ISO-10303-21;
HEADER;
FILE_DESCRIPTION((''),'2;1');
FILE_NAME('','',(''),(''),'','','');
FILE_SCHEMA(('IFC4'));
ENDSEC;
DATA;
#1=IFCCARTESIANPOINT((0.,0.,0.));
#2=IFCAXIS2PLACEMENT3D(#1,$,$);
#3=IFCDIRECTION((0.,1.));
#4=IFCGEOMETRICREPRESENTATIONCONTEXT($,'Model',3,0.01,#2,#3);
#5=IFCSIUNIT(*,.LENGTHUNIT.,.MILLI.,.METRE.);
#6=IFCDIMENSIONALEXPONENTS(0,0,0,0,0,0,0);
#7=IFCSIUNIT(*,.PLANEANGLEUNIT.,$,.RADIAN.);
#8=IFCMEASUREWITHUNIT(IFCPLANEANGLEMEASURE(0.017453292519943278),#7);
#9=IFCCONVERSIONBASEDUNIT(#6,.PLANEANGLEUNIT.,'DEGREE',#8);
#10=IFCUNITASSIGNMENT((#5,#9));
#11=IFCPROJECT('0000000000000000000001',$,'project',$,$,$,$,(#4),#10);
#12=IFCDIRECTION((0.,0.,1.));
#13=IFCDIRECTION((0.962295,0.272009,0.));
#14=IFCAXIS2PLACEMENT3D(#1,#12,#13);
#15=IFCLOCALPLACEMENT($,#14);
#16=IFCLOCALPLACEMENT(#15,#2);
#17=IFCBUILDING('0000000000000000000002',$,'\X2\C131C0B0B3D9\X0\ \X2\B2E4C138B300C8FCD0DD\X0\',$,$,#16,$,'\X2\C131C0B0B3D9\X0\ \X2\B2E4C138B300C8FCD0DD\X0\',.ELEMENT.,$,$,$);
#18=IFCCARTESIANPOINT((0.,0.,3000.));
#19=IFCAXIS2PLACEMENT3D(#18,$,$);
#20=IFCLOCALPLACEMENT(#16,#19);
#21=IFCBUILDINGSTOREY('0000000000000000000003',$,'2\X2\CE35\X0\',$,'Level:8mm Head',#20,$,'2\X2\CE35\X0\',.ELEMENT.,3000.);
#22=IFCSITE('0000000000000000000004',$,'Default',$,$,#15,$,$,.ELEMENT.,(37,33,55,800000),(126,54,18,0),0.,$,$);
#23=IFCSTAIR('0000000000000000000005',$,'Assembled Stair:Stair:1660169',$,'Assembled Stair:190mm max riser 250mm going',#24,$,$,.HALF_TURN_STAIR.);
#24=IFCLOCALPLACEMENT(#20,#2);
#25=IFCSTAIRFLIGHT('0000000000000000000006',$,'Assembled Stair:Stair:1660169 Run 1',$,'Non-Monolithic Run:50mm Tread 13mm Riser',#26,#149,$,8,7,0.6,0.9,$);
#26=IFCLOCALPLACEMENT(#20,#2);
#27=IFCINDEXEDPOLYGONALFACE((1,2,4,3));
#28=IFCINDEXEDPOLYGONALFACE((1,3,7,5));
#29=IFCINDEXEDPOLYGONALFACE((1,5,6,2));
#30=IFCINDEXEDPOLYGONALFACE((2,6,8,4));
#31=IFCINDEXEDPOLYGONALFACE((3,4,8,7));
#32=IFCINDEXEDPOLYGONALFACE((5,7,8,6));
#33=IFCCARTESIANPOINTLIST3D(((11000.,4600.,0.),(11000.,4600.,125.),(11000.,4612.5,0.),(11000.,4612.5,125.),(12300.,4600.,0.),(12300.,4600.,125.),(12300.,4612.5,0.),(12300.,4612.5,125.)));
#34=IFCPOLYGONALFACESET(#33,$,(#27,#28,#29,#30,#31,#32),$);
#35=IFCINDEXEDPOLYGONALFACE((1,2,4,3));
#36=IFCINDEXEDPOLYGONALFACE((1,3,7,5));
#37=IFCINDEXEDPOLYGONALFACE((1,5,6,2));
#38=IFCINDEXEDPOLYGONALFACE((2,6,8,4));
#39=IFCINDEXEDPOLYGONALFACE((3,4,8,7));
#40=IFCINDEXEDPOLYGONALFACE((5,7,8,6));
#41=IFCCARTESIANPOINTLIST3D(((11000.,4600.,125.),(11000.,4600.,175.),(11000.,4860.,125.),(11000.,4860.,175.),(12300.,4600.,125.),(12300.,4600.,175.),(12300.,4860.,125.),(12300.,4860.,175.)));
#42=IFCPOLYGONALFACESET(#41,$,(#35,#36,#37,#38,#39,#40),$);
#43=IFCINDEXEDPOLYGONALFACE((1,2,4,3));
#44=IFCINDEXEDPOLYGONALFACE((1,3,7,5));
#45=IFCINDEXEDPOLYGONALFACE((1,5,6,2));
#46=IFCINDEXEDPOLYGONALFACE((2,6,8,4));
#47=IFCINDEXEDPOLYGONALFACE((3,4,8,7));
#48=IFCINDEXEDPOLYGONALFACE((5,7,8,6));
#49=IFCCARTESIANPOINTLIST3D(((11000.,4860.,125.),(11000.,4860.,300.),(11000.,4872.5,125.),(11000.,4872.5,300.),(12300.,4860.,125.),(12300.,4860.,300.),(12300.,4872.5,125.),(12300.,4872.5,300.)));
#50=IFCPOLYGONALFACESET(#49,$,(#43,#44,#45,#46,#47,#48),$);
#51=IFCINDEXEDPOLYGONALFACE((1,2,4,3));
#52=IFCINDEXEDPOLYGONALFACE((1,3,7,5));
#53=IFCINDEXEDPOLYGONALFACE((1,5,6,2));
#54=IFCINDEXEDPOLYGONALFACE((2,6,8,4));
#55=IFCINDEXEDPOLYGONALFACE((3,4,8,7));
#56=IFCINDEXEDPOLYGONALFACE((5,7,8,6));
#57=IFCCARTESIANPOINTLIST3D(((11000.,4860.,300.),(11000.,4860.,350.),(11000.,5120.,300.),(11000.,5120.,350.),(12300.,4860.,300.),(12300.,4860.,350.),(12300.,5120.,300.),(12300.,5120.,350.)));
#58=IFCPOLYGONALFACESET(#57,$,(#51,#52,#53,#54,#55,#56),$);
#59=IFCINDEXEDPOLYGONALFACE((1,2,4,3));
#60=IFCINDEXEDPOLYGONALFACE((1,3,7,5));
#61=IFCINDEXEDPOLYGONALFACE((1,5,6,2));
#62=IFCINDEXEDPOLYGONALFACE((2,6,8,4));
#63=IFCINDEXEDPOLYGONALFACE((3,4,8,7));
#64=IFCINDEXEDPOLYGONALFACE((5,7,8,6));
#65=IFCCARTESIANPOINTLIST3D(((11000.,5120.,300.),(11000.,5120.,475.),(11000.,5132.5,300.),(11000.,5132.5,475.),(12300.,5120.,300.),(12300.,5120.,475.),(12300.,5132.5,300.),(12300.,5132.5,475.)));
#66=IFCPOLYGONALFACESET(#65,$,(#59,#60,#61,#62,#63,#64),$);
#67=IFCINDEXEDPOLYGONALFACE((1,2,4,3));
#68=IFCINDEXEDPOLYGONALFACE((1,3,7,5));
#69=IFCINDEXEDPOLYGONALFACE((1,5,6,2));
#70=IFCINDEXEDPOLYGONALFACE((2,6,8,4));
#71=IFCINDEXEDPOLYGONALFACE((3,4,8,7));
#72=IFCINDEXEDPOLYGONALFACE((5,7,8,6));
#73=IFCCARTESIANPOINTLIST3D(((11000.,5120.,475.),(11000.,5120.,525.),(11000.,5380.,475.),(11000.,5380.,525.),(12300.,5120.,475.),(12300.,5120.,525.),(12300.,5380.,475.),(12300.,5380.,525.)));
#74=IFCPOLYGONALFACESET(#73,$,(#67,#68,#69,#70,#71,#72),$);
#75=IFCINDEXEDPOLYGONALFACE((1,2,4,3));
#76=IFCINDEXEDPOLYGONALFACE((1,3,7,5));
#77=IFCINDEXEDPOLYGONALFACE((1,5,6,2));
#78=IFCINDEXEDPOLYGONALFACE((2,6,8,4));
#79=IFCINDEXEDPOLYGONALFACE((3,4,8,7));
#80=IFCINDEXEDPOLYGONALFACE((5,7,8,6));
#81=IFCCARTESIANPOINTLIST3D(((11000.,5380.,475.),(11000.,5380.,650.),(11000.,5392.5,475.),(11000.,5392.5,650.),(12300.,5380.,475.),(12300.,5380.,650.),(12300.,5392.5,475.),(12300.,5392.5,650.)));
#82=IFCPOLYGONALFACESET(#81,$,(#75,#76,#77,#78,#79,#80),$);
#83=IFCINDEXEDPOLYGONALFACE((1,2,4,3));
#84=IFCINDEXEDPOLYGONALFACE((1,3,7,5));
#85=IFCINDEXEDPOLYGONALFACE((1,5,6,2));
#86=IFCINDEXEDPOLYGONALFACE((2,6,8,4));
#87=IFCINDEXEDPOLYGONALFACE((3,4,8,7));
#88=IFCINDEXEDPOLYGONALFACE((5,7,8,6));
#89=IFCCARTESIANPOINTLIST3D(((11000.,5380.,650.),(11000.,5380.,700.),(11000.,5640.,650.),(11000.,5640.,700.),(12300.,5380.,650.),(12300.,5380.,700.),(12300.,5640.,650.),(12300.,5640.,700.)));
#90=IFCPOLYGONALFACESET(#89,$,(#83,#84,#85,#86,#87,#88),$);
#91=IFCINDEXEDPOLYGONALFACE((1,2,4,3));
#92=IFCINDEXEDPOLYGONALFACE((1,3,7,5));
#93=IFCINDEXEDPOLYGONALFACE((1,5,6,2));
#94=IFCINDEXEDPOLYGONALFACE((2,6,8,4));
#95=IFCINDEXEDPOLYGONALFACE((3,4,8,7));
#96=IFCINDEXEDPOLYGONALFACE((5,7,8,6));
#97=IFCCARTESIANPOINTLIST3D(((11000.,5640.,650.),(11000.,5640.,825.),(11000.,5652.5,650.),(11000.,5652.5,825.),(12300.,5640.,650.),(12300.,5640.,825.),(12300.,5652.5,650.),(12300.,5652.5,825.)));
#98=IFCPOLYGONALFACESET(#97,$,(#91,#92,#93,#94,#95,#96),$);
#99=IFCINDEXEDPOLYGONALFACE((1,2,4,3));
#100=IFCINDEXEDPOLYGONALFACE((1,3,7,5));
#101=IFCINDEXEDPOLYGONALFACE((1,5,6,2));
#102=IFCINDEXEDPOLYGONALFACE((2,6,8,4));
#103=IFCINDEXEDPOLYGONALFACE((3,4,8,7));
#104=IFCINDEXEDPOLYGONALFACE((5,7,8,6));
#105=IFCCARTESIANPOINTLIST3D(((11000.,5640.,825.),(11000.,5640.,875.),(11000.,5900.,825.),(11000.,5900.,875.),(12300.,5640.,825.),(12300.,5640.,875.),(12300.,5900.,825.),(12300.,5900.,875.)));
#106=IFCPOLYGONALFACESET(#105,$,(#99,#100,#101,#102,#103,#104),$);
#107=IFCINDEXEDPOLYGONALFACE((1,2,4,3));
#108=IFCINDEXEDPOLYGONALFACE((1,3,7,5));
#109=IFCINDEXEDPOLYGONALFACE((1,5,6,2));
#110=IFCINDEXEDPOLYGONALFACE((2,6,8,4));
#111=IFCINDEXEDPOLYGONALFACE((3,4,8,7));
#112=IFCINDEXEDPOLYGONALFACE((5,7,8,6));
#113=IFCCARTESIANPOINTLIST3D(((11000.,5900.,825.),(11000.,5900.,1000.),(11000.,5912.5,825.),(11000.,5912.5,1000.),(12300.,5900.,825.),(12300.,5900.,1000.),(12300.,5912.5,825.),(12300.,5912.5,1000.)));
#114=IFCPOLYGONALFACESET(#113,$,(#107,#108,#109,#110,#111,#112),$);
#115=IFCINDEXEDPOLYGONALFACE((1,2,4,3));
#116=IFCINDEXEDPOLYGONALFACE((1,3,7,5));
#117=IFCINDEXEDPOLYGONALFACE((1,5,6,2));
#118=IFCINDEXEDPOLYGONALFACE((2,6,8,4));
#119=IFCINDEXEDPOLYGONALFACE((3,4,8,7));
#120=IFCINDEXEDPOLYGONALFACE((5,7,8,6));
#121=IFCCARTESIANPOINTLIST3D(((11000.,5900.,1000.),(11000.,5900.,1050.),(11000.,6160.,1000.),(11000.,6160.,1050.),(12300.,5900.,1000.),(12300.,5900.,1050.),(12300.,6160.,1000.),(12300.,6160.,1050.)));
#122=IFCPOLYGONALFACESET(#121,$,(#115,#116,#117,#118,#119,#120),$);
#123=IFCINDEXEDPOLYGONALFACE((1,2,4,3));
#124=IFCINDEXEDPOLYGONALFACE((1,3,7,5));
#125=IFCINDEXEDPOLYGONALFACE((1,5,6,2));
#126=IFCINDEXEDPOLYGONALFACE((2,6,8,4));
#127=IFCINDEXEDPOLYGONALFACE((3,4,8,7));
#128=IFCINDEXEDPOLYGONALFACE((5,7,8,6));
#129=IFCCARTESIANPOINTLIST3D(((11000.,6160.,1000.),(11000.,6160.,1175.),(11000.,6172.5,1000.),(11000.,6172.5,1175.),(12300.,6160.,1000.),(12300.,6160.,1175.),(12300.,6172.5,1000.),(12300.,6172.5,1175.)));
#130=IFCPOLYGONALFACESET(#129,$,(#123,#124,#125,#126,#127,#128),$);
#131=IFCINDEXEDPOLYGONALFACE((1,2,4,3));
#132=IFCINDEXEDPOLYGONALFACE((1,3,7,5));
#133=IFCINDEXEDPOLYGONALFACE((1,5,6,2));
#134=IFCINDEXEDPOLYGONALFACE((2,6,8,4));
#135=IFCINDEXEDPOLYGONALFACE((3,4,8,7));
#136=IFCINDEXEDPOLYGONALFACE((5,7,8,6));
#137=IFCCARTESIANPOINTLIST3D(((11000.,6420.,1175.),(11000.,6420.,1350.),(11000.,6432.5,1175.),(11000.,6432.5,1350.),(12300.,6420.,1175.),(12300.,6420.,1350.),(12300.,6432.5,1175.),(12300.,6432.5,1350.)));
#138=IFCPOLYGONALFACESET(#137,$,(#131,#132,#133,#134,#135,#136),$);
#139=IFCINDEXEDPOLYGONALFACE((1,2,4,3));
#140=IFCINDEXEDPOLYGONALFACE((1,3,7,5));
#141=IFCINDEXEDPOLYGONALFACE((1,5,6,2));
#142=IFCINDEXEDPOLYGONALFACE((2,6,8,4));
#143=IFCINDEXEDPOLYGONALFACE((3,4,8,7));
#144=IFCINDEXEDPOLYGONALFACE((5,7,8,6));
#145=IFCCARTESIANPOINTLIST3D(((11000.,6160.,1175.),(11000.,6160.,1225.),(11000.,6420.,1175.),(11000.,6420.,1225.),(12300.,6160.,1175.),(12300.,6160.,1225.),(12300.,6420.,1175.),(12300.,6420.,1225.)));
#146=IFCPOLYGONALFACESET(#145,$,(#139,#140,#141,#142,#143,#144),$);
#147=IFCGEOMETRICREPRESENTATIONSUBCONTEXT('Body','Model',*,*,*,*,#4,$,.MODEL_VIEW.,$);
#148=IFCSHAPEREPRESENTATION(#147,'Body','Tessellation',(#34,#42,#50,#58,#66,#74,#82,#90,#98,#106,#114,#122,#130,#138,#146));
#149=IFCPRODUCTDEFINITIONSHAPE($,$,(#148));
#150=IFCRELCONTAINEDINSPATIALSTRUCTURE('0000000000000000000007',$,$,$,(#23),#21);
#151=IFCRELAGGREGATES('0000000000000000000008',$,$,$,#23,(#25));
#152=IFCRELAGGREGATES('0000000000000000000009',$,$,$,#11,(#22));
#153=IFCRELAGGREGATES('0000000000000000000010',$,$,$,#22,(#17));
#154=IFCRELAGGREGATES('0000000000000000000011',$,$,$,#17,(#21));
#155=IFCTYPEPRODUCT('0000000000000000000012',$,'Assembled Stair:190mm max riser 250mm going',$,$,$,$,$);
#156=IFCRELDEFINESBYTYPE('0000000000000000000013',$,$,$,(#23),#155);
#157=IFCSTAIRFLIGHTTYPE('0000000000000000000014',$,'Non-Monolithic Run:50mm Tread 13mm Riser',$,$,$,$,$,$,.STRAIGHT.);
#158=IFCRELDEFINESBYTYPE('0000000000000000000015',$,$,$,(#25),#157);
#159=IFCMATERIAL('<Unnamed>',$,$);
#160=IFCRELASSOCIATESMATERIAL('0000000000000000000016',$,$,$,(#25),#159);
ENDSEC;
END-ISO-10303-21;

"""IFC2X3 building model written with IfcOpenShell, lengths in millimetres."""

from ifc_helpers import new_model, entity, si_unit, converted_unit, direction, frame, frame_2d, origin, origin_2d_with_axis, place, context, subcontext, project, spatial, rectangle, extrude, material, type_object, element, aggregate, save


model = new_model("IFC2X3")

# Units and contexts
model_context = context("Model", 3, precision=0.01, world=origin(), true_north=direction((0.0, 1.0)))
body_context = subcontext(model_context, "Body", "Model", "MODEL_VIEW")
ifc_project = project(units=[si_unit("LENGTHUNIT", "METRE", prefix="MILLI"), converted_unit("PLANEANGLEUNIT", "DEGREE", entity("IfcPlaneAngleMeasure", 0.017453292519943278), si_unit("PLANEANGLEUNIT", "RADIAN"), dimensions=[0, 0, 0, 0, 0, 0, 0])], contexts=[model_context])

# Site, building, storey
site_placement = place(None, frame((0.0, 0.0, 0.0), z_axis=(0.0, 0.0, 1.0), x_axis=(0.962295, 0.272009, 0.0)))
site = spatial("IfcSite", under=ifc_project, at=site_placement, Name="Default", CompositionType="ELEMENT", RefLatitude=(37, 33, 55, 800000), RefLongitude=(126, 54, 18, 0), RefElevation=0.0)
building_placement = place(site_placement, origin())
building = spatial("IfcBuilding", under=site, at=building_placement, Name="성산동 다세대주택", LongName="성산동 다세대주택", CompositionType="ELEMENT")
storey_placement = place(building_placement, frame((0.0, 0.0, 3000.0)))
storey = spatial("IfcBuildingStorey", under=building, at=storey_placement, Name="2층", ObjectType="Level:8mm Head", LongName="2층", CompositionType="ELEMENT", Elevation=3000.0)

# Stair
type_product = type_object("IfcTypeProduct", Name="Assembled Stair:190mm max riser 250mm going")
stair_placement = place(storey_placement, origin())
stair = element("IfcStair", 1, at=stair_placement, inside=storey, type_object=type_product, Name="Assembled Stair:Stair:1660169", ObjectType="Assembled Stair:190mm max riser 250mm going", ShapeType="HALF_TURN_STAIR")
ifc_material_1 = material(Name="<Unnamed>")

# Stair flight
stair_flight_type = type_object("IfcStairFlightType", Name="Non-Monolithic Run:50mm Tread 13mm Riser", PredefinedType="STRAIGHT")
stair_flight_1_placement = place(stair_placement, origin())
stair_flight_1 = element("IfcStairFlight", 2, at=stair_flight_1_placement, type_object=stair_flight_type, material=ifc_material_1, Name="Assembled Stair:Stair:1660169 Run 1", ObjectType="Non-Monolithic Run:50mm Tread 13mm Riser", NumberOfRiser=8, NumberOfTreads=7, RiserHeight=0.6, TreadLength=0.9, context=body_context, shape_type="SweptSolid", body=[
    extrude(rectangle(XDim=1300.0, YDim=12.5, at=frame_2d((0.0, 0.0), x_axis=(1.0, 0.0))), frame((11650.0, 4606.2, 0.0), z_axis=(0.0, 0.0, 1.0), x_axis=(-1.0, 0.0, 0.0)), (0.0, 0.0, 1.0), 125.0),
    extrude(rectangle(XDim=260.0, YDim=1300.0, at=frame_2d((0.0, 0.0), x_axis=(1.0, 0.0))), frame((11650.0, 4730.0, 125.0), z_axis=(0.0, 0.0, 1.0), x_axis=(0.0, -1.0, 0.0)), (0.0, 0.0, 1.0), 50.0),
    extrude(rectangle(XDim=1300.0, YDim=12.5, at=frame_2d((0.0, 0.0), x_axis=(1.0, 0.0))), frame((11650.0, 4866.2, 125.0), z_axis=(0.0, 0.0, 1.0), x_axis=(-1.0, 0.0, 0.0)), (0.0, 0.0, 1.0), 175.0),
    extrude(rectangle(XDim=260.0, YDim=1300.0, at=frame_2d((0.0, 0.0), x_axis=(1.0, 0.0))), frame((11650.0, 4990.0, 300.0), z_axis=(0.0, 0.0, 1.0), x_axis=(0.0, -1.0, 0.0)), (0.0, 0.0, 1.0), 50.0),
    extrude(rectangle(XDim=1300.0, YDim=12.5, at=origin_2d_with_axis()), frame((11650.0, 5126.2, 300.0), z_axis=(0.0, 0.0, 1.0), x_axis=(-1.0, 0.0, 0.0)), (0.0, 0.0, 1.0), 175.0),
    extrude(rectangle(XDim=260.0, YDim=1300.0, at=frame_2d((0.0, 0.0), x_axis=(1.0, 0.0))), frame((11650.0, 5250.0, 475.0), z_axis=(0.0, 0.0, 1.0), x_axis=(0.0, -1.0, 0.0)), (0.0, 0.0, 1.0), 50.0),
    extrude(rectangle(XDim=1300.0, YDim=12.5, at=frame_2d((0.0, 0.0), x_axis=(1.0, 0.0))), frame((11650.0, 5386.2, 475.0), z_axis=(0.0, 0.0, 1.0), x_axis=(-1.0, 0.0, 0.0)), (0.0, 0.0, 1.0), 175.0),
    extrude(rectangle(XDim=260.0, YDim=1300.0, at=origin_2d_with_axis()), frame((11650.0, 5510.0, 650.0), z_axis=(0.0, 0.0, 1.0), x_axis=(0.0, -1.0, 0.0)), (0.0, 0.0, 1.0), 50.0),
    extrude(rectangle(XDim=1300.0, YDim=12.5, at=frame_2d((0.0, 0.0), x_axis=(1.0, 0.0))), frame((11650.0, 5646.2, 650.0), z_axis=(0.0, 0.0, 1.0), x_axis=(-1.0, 0.0, 0.0)), (0.0, 0.0, 1.0), 175.0),
    extrude(rectangle(XDim=260.0, YDim=1300.0, at=origin_2d_with_axis()), frame((11650.0, 5770.0, 825.0), z_axis=(0.0, 0.0, 1.0), x_axis=(0.0, -1.0, 0.0)), (0.0, 0.0, 1.0), 50.0),
    extrude(rectangle(XDim=1300.0, YDim=12.5, at=origin_2d_with_axis()), frame((11650.0, 5906.2, 825.0), z_axis=(0.0, 0.0, 1.0), x_axis=(-1.0, 0.0, 0.0)), (0.0, 0.0, 1.0), 175.0),
    extrude(rectangle(XDim=260.0, YDim=1300.0, at=origin_2d_with_axis()), frame((11650.0, 6030.0, 1000.0), z_axis=(0.0, 0.0, 1.0), x_axis=(0.0, -1.0, 0.0)), (0.0, 0.0, 1.0), 50.0),
    extrude(rectangle(XDim=1300.0, YDim=12.5, at=frame_2d((0.0, 0.0), x_axis=(1.0, 0.0))), frame((11650.0, 6166.2, 1000.0), z_axis=(0.0, 0.0, 1.0), x_axis=(-1.0, 0.0, 0.0)), (0.0, 0.0, 1.0), 175.0),
    extrude(rectangle(XDim=1300.0, YDim=12.5, at=frame_2d((0.0, 0.0), x_axis=(1.0, 0.0))), frame((11650.0, 6426.3, 1175.0), z_axis=(0.0, 0.0, 1.0), x_axis=(-1.0, 0.0, 0.0)), (0.0, 0.0, 1.0), 175.0),
    extrude(rectangle(XDim=260.0, YDim=1300.0, at=origin_2d_with_axis()), frame((11650.0, 6290.0, 1175.0), z_axis=(0.0, 0.0, 1.0), x_axis=(0.0, -1.0, 0.0)), (0.0, 0.0, 1.0), 50.0),
])
aggregate(stair, [stair_flight_1])

save(model, "model.ifc")
